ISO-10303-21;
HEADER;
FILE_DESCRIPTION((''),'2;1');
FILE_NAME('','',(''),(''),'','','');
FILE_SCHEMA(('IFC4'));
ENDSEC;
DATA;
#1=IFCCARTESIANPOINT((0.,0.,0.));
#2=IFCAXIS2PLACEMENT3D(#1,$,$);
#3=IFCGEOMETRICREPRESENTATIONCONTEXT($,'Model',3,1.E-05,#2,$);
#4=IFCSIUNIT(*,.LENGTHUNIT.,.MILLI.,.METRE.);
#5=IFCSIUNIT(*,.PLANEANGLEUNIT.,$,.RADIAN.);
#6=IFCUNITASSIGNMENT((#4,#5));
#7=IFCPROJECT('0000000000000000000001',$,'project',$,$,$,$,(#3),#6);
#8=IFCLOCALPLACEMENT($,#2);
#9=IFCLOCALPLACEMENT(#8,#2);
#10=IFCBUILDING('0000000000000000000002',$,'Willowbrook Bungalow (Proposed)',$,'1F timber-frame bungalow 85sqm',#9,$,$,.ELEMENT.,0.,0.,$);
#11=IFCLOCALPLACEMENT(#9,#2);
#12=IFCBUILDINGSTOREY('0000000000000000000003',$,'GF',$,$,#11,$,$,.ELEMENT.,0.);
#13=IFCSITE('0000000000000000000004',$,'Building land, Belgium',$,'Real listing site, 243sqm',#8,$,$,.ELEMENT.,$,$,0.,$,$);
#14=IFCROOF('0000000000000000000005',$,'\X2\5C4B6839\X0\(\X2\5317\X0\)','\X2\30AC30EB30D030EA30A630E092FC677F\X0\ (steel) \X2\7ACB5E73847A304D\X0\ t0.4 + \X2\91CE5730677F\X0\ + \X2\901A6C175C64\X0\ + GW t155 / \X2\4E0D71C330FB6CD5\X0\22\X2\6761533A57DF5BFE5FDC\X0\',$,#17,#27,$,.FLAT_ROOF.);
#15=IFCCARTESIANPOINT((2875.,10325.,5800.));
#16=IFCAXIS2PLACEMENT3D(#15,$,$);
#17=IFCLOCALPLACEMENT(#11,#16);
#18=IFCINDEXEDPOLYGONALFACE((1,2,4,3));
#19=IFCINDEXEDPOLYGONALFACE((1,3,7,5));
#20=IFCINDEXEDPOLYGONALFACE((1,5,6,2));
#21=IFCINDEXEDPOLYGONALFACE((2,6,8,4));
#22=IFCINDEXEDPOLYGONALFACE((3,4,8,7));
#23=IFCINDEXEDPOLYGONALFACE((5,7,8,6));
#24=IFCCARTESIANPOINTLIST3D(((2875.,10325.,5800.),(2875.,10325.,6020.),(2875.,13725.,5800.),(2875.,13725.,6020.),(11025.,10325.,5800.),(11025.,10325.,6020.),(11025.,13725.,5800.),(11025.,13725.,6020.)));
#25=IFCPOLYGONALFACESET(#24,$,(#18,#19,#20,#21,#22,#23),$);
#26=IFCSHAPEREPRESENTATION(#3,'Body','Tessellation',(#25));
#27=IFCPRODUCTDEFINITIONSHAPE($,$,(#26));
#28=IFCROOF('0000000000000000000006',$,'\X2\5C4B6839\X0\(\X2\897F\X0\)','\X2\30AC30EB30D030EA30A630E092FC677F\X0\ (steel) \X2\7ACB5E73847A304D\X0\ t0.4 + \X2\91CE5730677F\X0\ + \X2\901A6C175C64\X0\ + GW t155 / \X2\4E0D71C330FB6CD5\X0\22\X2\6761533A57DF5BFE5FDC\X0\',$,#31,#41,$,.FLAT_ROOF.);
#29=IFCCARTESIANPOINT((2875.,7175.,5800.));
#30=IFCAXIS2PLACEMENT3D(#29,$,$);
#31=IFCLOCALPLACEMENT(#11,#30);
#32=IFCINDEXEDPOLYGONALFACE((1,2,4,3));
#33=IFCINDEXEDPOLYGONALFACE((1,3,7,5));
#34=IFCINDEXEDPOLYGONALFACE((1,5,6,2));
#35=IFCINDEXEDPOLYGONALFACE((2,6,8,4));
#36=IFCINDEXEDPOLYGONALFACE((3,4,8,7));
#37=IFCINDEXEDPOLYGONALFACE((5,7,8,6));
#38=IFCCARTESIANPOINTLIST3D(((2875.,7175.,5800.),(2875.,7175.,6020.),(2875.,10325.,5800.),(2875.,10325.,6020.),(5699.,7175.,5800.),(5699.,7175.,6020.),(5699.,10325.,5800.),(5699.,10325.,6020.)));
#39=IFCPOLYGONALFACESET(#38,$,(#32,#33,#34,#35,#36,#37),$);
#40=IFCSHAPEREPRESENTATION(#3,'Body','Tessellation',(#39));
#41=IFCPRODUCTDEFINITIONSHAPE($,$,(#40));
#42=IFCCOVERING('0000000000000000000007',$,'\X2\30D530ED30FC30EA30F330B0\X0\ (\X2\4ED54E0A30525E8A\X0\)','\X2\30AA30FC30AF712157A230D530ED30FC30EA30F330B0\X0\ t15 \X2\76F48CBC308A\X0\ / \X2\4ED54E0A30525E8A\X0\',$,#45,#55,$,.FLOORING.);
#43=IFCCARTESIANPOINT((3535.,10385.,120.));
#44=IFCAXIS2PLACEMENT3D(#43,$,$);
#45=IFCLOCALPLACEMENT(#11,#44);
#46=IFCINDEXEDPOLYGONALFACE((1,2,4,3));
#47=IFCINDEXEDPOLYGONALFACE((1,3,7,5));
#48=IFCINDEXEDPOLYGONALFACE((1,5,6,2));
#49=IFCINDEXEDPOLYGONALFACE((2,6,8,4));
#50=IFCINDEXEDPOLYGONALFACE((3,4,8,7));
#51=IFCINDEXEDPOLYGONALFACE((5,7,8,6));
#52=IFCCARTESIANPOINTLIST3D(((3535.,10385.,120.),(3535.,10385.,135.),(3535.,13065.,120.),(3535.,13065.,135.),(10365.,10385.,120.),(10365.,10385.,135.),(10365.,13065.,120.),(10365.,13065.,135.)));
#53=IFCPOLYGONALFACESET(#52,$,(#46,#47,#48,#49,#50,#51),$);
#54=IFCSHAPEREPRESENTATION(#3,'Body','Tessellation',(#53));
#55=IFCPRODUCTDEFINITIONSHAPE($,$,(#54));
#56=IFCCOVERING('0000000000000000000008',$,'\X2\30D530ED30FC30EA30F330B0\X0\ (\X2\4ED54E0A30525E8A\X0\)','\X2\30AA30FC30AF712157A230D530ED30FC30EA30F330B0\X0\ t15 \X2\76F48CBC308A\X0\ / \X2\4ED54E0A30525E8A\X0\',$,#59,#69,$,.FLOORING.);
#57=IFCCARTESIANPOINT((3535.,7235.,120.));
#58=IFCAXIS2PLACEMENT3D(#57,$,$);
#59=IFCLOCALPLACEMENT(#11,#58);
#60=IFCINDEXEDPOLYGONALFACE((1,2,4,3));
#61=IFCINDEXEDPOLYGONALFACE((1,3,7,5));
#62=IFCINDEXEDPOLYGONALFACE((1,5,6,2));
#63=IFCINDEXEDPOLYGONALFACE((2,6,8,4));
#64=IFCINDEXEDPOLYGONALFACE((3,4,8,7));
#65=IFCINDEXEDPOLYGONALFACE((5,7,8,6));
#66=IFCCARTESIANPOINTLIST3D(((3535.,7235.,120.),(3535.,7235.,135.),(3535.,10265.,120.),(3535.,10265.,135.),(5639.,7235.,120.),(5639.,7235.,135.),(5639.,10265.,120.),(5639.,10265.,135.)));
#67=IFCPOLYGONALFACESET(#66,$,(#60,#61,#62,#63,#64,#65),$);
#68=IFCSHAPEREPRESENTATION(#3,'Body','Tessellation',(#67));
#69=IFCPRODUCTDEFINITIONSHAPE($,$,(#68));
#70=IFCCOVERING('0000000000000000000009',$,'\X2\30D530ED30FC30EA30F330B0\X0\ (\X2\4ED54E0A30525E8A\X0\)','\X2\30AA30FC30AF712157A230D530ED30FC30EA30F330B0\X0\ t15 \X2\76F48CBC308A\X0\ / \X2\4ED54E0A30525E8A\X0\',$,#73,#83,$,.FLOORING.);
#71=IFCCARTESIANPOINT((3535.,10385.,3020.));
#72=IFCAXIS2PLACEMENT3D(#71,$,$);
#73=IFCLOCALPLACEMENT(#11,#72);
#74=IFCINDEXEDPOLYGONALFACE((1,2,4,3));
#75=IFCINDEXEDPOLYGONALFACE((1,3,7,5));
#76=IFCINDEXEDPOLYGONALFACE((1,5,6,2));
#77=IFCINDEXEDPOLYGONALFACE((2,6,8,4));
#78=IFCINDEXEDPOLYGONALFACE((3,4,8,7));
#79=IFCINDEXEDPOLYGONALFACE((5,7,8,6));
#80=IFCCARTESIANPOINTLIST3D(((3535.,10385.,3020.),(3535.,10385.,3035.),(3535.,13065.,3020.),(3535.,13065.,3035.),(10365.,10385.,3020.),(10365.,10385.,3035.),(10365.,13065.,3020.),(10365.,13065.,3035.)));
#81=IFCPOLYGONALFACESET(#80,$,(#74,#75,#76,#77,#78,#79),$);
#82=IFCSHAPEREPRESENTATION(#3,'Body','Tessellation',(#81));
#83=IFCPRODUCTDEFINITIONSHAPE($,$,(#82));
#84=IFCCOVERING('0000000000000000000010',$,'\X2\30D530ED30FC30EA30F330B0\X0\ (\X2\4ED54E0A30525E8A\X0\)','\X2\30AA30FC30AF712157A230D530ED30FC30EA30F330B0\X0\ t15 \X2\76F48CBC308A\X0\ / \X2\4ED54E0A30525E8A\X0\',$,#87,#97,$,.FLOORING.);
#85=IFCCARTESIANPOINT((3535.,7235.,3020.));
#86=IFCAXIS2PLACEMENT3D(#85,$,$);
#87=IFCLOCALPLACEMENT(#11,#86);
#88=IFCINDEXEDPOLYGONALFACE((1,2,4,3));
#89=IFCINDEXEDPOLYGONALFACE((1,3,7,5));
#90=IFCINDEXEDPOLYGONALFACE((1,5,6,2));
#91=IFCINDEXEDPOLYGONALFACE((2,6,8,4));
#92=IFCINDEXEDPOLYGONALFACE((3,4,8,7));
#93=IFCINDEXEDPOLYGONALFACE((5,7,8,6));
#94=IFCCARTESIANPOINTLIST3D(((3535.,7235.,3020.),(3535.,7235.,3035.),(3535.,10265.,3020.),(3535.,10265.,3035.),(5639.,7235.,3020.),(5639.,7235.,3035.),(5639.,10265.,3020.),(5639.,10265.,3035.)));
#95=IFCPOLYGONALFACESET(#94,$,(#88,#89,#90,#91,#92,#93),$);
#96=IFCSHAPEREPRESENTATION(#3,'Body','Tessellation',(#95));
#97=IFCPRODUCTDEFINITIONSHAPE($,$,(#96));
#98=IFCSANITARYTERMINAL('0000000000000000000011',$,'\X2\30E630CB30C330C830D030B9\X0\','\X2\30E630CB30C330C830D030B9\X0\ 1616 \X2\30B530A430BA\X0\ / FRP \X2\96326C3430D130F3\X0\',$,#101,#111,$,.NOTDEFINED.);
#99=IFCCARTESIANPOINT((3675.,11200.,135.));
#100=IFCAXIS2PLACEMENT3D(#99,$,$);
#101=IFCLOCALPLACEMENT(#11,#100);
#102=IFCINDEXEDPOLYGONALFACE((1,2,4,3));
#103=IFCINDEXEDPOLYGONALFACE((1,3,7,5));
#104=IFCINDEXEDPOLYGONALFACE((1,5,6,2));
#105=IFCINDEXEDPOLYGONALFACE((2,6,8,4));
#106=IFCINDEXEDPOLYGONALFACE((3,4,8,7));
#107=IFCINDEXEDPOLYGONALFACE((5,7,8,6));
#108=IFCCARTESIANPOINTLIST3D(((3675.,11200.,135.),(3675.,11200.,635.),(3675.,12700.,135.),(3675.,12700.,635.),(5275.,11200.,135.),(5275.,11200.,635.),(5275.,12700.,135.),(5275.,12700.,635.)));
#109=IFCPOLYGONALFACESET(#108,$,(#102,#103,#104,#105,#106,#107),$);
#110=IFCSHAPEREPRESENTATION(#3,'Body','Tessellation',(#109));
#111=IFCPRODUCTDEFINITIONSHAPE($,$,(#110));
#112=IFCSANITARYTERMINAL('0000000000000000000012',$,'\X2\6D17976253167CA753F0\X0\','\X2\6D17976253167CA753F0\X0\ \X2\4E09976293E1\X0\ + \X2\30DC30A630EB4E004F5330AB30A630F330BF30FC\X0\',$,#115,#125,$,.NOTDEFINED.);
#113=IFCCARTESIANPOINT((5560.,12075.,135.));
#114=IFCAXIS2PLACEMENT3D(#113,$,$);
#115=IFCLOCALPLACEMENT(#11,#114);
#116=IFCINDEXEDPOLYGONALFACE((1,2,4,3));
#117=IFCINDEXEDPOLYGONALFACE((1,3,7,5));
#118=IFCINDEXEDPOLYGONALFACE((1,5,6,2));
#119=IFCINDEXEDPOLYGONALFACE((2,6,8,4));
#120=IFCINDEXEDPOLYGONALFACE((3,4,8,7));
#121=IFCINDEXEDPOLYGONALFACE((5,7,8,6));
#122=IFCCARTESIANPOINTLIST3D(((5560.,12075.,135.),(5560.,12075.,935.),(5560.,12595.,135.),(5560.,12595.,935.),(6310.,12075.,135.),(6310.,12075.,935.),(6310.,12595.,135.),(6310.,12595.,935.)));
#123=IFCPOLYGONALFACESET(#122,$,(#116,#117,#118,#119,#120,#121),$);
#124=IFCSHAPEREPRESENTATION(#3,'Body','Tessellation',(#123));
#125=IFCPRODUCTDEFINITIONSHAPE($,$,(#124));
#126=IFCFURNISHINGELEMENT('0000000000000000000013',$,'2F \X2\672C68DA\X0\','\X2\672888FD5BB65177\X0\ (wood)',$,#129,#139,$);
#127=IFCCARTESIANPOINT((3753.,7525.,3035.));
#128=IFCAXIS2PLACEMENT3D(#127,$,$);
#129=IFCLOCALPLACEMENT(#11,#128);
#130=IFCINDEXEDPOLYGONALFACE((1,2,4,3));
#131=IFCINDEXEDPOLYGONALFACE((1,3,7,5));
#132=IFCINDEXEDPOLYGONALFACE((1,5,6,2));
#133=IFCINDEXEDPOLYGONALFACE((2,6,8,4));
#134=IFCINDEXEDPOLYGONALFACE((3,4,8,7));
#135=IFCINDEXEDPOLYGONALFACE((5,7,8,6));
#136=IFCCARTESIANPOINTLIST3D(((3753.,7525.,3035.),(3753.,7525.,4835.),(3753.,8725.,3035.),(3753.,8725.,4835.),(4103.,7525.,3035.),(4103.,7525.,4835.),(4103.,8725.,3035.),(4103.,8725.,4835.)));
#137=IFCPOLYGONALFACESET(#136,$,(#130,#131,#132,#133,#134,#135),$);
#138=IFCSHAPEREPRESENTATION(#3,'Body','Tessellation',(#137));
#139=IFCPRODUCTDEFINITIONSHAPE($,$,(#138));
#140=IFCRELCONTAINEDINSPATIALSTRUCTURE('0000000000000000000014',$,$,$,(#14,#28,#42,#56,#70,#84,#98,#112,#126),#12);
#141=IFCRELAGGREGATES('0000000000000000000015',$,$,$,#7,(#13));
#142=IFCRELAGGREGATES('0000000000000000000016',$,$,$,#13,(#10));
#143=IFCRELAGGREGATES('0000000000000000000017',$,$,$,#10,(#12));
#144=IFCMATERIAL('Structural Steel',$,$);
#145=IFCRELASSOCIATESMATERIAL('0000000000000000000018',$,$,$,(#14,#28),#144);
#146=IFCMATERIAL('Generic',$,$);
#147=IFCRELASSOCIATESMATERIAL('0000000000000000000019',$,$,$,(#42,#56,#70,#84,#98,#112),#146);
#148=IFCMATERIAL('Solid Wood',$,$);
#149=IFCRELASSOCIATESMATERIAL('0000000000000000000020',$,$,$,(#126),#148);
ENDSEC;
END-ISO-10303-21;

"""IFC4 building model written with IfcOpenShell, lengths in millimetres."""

from ifc_helpers import new_model, si_unit, frame, frame_2d, origin, place, context, project, spatial, rectangle, extrude, material, element, save


model = new_model("IFC4")

# Units and contexts
model_context = context("Model", 3, precision=1e-05, world=origin())
ifc_project = project(units=[si_unit("LENGTHUNIT", "METRE", prefix="MILLI"), si_unit("PLANEANGLEUNIT", "RADIAN")], contexts=[model_context])

# Site, building, storey
site_placement = place(None, origin())
site = spatial("IfcSite", under=ifc_project, at=site_placement, Name="Building land, Belgium", ObjectType="Real listing site, 243sqm", CompositionType="ELEMENT", RefElevation=0.0)
building_placement = place(site_placement, origin())
building = spatial("IfcBuilding", under=site, at=building_placement, Name="Willowbrook Bungalow (Proposed)", ObjectType="1F timber-frame bungalow 85sqm", CompositionType="ELEMENT", ElevationOfRefHeight=0.0, ElevationOfTerrain=0.0)
storey_placement = place(building_placement, origin())
storey = spatial("IfcBuildingStorey", under=building, at=storey_placement, Name="GF", CompositionType="ELEMENT", Elevation=0.0)

# Shared definitions
ifc_material_1 = material(Name="Solid Wood")

# Roofs
ifc_material_2 = material(Name="Structural Steel")
for number, where, name in (
    (1, (2875.0, 10325.0, 5800.0), "屋根(北)"),
):
    element("IfcRoof", number, at=place(storey_placement, frame(where)), inside=storey, material=ifc_material_2, Name=name, Description="ガルバリウム鋼板 (steel) 立平葺き t0.4 + 野地板 + 通気層 + GW t155 / 不燃・法22条区域対応", PredefinedType="FLAT_ROOF", context=model_context, shape_type="SweptSolid", body=[
        extrude(rectangle(XDim=8150.0, YDim=3400.0, at=frame_2d((4075.0, 1700.0))), frame((2875.0, 10325.0, 5800.0)), (0.0, 0.0, 1.0), 220.0),
    ])
roof_placement = place(storey_placement, frame((2875.0, 7175.0, 5800.0)))
element("IfcRoof", 2, at=roof_placement, inside=storey, material=ifc_material_2, Name="屋根(西)", Description="ガルバリウム鋼板 (steel) 立平葺き t0.4 + 野地板 + 通気層 + GW t155 / 不燃・法22条区域対応", PredefinedType="FLAT_ROOF", context=model_context, shape_type="SweptSolid", body=[
    extrude(rectangle(XDim=2824.0, YDim=3150.0, at=frame_2d((1412.0, 1575.0))), frame((2875.0, 7175.0, 5800.0)), (0.0, 0.0, 1.0), 220.0),
])

# Coverings
ifc_material_3 = material(Name="Generic")
covering_1_placement = place(storey_placement, frame((3535.0, 10385.0, 120.0)))
element("IfcCovering", 3, at=covering_1_placement, inside=storey, material=ifc_material_3, Name="フローリング (仕上げ床)", Description="オーク無垢フローリング t15 直貼り / 仕上げ床", PredefinedType="FLOORING", context=model_context, shape_type="SweptSolid", body=[
    extrude(rectangle(XDim=6830.0, YDim=2680.0, at=frame_2d((3415.0, 1340.0))), frame((3535.0, 10385.0, 120.0)), (0.0, 0.0, 1.0), 15.0),
])
covering_2_placement = place(storey_placement, frame((3535.0, 7235.0, 120.0)))
element("IfcCovering", 4, at=covering_2_placement, inside=storey, material=ifc_material_3, Name="フローリング (仕上げ床)", Description="オーク無垢フローリング t15 直貼り / 仕上げ床", PredefinedType="FLOORING", context=model_context, shape_type="SweptSolid", body=[
    extrude(rectangle(XDim=2104.0, YDim=3030.0, at=frame_2d((1052.0, 1515.0))), frame((3535.0, 7235.0, 120.0)), (0.0, 0.0, 1.0), 15.0),
])
covering_3_placement = place(storey_placement, frame((3535.0, 10385.0, 3020.0)))
element("IfcCovering", 5, at=covering_3_placement, inside=storey, material=ifc_material_3, Name="フローリング (仕上げ床)", Description="オーク無垢フローリング t15 直貼り / 仕上げ床", PredefinedType="FLOORING", context=model_context, shape_type="SweptSolid", body=[
    extrude(rectangle(XDim=6830.0, YDim=2680.0, at=frame_2d((3415.0, 1340.0))), frame((3535.0, 10385.0, 3020.0)), (0.0, 0.0, 1.0), 15.0),
])
covering_4_placement = place(storey_placement, frame((3535.0, 7235.0, 3020.0)))
element("IfcCovering", 6, at=covering_4_placement, inside=storey, material=ifc_material_3, Name="フローリング (仕上げ床)", Description="オーク無垢フローリング t15 直貼り / 仕上げ床", PredefinedType="FLOORING", context=model_context, shape_type="SweptSolid", body=[
    extrude(rectangle(XDim=2104.0, YDim=3030.0, at=frame_2d((1052.0, 1515.0))), frame((3535.0, 7235.0, 3020.0)), (0.0, 0.0, 1.0), 15.0),
])

# Sanitary terminals
sanitary_terminal_1_placement = place(storey_placement, frame((3675.0, 11200.0, 135.0)))
element("IfcSanitaryTerminal", 7, at=sanitary_terminal_1_placement, inside=storey, material=ifc_material_3, Name="ユニットバス", Description="ユニットバス 1616 サイズ / FRP 防水パン", PredefinedType="NOTDEFINED", context=model_context, shape_type="SweptSolid", body=[
    extrude(rectangle(XDim=1600.0, YDim=1500.0, at=frame_2d((800.0, 750.0))), frame((3675.0, 11200.0, 135.0)), (0.0, 0.0, 1.0), 500.0),
])
sanitary_terminal_2_placement = place(storey_placement, frame((5560.0, 12075.0, 135.0)))
element("IfcSanitaryTerminal", 8, at=sanitary_terminal_2_placement, inside=storey, material=ifc_material_3, Name="洗面化粧台", Description="洗面化粧台 三面鏡 + ボウル一体カウンター", PredefinedType="NOTDEFINED", context=model_context, shape_type="SweptSolid", body=[
    extrude(rectangle(XDim=750.0, YDim=520.0, at=frame_2d((375.0, 260.0))), frame((5560.0, 12075.0, 135.0)), (0.0, 0.0, 1.0), 800.0),
])

# Furnishing element
furnishing_placement = place(storey_placement, frame((3753.0, 7525.0, 3035.0)))
element("IfcFurnishingElement", 9, at=furnishing_placement, inside=storey, material=ifc_material_1, Name="2F 本棚", Description="木製家具 (wood)", context=model_context, shape_type="SweptSolid", body=[
    extrude(rectangle(XDim=350.0, YDim=1200.0, at=frame_2d((175.0, 600.0))), frame((3753.0, 7525.0, 3035.0)), (0.0, 0.0, 1.0), 1800.0),
])

save(model, "model.ifc")
